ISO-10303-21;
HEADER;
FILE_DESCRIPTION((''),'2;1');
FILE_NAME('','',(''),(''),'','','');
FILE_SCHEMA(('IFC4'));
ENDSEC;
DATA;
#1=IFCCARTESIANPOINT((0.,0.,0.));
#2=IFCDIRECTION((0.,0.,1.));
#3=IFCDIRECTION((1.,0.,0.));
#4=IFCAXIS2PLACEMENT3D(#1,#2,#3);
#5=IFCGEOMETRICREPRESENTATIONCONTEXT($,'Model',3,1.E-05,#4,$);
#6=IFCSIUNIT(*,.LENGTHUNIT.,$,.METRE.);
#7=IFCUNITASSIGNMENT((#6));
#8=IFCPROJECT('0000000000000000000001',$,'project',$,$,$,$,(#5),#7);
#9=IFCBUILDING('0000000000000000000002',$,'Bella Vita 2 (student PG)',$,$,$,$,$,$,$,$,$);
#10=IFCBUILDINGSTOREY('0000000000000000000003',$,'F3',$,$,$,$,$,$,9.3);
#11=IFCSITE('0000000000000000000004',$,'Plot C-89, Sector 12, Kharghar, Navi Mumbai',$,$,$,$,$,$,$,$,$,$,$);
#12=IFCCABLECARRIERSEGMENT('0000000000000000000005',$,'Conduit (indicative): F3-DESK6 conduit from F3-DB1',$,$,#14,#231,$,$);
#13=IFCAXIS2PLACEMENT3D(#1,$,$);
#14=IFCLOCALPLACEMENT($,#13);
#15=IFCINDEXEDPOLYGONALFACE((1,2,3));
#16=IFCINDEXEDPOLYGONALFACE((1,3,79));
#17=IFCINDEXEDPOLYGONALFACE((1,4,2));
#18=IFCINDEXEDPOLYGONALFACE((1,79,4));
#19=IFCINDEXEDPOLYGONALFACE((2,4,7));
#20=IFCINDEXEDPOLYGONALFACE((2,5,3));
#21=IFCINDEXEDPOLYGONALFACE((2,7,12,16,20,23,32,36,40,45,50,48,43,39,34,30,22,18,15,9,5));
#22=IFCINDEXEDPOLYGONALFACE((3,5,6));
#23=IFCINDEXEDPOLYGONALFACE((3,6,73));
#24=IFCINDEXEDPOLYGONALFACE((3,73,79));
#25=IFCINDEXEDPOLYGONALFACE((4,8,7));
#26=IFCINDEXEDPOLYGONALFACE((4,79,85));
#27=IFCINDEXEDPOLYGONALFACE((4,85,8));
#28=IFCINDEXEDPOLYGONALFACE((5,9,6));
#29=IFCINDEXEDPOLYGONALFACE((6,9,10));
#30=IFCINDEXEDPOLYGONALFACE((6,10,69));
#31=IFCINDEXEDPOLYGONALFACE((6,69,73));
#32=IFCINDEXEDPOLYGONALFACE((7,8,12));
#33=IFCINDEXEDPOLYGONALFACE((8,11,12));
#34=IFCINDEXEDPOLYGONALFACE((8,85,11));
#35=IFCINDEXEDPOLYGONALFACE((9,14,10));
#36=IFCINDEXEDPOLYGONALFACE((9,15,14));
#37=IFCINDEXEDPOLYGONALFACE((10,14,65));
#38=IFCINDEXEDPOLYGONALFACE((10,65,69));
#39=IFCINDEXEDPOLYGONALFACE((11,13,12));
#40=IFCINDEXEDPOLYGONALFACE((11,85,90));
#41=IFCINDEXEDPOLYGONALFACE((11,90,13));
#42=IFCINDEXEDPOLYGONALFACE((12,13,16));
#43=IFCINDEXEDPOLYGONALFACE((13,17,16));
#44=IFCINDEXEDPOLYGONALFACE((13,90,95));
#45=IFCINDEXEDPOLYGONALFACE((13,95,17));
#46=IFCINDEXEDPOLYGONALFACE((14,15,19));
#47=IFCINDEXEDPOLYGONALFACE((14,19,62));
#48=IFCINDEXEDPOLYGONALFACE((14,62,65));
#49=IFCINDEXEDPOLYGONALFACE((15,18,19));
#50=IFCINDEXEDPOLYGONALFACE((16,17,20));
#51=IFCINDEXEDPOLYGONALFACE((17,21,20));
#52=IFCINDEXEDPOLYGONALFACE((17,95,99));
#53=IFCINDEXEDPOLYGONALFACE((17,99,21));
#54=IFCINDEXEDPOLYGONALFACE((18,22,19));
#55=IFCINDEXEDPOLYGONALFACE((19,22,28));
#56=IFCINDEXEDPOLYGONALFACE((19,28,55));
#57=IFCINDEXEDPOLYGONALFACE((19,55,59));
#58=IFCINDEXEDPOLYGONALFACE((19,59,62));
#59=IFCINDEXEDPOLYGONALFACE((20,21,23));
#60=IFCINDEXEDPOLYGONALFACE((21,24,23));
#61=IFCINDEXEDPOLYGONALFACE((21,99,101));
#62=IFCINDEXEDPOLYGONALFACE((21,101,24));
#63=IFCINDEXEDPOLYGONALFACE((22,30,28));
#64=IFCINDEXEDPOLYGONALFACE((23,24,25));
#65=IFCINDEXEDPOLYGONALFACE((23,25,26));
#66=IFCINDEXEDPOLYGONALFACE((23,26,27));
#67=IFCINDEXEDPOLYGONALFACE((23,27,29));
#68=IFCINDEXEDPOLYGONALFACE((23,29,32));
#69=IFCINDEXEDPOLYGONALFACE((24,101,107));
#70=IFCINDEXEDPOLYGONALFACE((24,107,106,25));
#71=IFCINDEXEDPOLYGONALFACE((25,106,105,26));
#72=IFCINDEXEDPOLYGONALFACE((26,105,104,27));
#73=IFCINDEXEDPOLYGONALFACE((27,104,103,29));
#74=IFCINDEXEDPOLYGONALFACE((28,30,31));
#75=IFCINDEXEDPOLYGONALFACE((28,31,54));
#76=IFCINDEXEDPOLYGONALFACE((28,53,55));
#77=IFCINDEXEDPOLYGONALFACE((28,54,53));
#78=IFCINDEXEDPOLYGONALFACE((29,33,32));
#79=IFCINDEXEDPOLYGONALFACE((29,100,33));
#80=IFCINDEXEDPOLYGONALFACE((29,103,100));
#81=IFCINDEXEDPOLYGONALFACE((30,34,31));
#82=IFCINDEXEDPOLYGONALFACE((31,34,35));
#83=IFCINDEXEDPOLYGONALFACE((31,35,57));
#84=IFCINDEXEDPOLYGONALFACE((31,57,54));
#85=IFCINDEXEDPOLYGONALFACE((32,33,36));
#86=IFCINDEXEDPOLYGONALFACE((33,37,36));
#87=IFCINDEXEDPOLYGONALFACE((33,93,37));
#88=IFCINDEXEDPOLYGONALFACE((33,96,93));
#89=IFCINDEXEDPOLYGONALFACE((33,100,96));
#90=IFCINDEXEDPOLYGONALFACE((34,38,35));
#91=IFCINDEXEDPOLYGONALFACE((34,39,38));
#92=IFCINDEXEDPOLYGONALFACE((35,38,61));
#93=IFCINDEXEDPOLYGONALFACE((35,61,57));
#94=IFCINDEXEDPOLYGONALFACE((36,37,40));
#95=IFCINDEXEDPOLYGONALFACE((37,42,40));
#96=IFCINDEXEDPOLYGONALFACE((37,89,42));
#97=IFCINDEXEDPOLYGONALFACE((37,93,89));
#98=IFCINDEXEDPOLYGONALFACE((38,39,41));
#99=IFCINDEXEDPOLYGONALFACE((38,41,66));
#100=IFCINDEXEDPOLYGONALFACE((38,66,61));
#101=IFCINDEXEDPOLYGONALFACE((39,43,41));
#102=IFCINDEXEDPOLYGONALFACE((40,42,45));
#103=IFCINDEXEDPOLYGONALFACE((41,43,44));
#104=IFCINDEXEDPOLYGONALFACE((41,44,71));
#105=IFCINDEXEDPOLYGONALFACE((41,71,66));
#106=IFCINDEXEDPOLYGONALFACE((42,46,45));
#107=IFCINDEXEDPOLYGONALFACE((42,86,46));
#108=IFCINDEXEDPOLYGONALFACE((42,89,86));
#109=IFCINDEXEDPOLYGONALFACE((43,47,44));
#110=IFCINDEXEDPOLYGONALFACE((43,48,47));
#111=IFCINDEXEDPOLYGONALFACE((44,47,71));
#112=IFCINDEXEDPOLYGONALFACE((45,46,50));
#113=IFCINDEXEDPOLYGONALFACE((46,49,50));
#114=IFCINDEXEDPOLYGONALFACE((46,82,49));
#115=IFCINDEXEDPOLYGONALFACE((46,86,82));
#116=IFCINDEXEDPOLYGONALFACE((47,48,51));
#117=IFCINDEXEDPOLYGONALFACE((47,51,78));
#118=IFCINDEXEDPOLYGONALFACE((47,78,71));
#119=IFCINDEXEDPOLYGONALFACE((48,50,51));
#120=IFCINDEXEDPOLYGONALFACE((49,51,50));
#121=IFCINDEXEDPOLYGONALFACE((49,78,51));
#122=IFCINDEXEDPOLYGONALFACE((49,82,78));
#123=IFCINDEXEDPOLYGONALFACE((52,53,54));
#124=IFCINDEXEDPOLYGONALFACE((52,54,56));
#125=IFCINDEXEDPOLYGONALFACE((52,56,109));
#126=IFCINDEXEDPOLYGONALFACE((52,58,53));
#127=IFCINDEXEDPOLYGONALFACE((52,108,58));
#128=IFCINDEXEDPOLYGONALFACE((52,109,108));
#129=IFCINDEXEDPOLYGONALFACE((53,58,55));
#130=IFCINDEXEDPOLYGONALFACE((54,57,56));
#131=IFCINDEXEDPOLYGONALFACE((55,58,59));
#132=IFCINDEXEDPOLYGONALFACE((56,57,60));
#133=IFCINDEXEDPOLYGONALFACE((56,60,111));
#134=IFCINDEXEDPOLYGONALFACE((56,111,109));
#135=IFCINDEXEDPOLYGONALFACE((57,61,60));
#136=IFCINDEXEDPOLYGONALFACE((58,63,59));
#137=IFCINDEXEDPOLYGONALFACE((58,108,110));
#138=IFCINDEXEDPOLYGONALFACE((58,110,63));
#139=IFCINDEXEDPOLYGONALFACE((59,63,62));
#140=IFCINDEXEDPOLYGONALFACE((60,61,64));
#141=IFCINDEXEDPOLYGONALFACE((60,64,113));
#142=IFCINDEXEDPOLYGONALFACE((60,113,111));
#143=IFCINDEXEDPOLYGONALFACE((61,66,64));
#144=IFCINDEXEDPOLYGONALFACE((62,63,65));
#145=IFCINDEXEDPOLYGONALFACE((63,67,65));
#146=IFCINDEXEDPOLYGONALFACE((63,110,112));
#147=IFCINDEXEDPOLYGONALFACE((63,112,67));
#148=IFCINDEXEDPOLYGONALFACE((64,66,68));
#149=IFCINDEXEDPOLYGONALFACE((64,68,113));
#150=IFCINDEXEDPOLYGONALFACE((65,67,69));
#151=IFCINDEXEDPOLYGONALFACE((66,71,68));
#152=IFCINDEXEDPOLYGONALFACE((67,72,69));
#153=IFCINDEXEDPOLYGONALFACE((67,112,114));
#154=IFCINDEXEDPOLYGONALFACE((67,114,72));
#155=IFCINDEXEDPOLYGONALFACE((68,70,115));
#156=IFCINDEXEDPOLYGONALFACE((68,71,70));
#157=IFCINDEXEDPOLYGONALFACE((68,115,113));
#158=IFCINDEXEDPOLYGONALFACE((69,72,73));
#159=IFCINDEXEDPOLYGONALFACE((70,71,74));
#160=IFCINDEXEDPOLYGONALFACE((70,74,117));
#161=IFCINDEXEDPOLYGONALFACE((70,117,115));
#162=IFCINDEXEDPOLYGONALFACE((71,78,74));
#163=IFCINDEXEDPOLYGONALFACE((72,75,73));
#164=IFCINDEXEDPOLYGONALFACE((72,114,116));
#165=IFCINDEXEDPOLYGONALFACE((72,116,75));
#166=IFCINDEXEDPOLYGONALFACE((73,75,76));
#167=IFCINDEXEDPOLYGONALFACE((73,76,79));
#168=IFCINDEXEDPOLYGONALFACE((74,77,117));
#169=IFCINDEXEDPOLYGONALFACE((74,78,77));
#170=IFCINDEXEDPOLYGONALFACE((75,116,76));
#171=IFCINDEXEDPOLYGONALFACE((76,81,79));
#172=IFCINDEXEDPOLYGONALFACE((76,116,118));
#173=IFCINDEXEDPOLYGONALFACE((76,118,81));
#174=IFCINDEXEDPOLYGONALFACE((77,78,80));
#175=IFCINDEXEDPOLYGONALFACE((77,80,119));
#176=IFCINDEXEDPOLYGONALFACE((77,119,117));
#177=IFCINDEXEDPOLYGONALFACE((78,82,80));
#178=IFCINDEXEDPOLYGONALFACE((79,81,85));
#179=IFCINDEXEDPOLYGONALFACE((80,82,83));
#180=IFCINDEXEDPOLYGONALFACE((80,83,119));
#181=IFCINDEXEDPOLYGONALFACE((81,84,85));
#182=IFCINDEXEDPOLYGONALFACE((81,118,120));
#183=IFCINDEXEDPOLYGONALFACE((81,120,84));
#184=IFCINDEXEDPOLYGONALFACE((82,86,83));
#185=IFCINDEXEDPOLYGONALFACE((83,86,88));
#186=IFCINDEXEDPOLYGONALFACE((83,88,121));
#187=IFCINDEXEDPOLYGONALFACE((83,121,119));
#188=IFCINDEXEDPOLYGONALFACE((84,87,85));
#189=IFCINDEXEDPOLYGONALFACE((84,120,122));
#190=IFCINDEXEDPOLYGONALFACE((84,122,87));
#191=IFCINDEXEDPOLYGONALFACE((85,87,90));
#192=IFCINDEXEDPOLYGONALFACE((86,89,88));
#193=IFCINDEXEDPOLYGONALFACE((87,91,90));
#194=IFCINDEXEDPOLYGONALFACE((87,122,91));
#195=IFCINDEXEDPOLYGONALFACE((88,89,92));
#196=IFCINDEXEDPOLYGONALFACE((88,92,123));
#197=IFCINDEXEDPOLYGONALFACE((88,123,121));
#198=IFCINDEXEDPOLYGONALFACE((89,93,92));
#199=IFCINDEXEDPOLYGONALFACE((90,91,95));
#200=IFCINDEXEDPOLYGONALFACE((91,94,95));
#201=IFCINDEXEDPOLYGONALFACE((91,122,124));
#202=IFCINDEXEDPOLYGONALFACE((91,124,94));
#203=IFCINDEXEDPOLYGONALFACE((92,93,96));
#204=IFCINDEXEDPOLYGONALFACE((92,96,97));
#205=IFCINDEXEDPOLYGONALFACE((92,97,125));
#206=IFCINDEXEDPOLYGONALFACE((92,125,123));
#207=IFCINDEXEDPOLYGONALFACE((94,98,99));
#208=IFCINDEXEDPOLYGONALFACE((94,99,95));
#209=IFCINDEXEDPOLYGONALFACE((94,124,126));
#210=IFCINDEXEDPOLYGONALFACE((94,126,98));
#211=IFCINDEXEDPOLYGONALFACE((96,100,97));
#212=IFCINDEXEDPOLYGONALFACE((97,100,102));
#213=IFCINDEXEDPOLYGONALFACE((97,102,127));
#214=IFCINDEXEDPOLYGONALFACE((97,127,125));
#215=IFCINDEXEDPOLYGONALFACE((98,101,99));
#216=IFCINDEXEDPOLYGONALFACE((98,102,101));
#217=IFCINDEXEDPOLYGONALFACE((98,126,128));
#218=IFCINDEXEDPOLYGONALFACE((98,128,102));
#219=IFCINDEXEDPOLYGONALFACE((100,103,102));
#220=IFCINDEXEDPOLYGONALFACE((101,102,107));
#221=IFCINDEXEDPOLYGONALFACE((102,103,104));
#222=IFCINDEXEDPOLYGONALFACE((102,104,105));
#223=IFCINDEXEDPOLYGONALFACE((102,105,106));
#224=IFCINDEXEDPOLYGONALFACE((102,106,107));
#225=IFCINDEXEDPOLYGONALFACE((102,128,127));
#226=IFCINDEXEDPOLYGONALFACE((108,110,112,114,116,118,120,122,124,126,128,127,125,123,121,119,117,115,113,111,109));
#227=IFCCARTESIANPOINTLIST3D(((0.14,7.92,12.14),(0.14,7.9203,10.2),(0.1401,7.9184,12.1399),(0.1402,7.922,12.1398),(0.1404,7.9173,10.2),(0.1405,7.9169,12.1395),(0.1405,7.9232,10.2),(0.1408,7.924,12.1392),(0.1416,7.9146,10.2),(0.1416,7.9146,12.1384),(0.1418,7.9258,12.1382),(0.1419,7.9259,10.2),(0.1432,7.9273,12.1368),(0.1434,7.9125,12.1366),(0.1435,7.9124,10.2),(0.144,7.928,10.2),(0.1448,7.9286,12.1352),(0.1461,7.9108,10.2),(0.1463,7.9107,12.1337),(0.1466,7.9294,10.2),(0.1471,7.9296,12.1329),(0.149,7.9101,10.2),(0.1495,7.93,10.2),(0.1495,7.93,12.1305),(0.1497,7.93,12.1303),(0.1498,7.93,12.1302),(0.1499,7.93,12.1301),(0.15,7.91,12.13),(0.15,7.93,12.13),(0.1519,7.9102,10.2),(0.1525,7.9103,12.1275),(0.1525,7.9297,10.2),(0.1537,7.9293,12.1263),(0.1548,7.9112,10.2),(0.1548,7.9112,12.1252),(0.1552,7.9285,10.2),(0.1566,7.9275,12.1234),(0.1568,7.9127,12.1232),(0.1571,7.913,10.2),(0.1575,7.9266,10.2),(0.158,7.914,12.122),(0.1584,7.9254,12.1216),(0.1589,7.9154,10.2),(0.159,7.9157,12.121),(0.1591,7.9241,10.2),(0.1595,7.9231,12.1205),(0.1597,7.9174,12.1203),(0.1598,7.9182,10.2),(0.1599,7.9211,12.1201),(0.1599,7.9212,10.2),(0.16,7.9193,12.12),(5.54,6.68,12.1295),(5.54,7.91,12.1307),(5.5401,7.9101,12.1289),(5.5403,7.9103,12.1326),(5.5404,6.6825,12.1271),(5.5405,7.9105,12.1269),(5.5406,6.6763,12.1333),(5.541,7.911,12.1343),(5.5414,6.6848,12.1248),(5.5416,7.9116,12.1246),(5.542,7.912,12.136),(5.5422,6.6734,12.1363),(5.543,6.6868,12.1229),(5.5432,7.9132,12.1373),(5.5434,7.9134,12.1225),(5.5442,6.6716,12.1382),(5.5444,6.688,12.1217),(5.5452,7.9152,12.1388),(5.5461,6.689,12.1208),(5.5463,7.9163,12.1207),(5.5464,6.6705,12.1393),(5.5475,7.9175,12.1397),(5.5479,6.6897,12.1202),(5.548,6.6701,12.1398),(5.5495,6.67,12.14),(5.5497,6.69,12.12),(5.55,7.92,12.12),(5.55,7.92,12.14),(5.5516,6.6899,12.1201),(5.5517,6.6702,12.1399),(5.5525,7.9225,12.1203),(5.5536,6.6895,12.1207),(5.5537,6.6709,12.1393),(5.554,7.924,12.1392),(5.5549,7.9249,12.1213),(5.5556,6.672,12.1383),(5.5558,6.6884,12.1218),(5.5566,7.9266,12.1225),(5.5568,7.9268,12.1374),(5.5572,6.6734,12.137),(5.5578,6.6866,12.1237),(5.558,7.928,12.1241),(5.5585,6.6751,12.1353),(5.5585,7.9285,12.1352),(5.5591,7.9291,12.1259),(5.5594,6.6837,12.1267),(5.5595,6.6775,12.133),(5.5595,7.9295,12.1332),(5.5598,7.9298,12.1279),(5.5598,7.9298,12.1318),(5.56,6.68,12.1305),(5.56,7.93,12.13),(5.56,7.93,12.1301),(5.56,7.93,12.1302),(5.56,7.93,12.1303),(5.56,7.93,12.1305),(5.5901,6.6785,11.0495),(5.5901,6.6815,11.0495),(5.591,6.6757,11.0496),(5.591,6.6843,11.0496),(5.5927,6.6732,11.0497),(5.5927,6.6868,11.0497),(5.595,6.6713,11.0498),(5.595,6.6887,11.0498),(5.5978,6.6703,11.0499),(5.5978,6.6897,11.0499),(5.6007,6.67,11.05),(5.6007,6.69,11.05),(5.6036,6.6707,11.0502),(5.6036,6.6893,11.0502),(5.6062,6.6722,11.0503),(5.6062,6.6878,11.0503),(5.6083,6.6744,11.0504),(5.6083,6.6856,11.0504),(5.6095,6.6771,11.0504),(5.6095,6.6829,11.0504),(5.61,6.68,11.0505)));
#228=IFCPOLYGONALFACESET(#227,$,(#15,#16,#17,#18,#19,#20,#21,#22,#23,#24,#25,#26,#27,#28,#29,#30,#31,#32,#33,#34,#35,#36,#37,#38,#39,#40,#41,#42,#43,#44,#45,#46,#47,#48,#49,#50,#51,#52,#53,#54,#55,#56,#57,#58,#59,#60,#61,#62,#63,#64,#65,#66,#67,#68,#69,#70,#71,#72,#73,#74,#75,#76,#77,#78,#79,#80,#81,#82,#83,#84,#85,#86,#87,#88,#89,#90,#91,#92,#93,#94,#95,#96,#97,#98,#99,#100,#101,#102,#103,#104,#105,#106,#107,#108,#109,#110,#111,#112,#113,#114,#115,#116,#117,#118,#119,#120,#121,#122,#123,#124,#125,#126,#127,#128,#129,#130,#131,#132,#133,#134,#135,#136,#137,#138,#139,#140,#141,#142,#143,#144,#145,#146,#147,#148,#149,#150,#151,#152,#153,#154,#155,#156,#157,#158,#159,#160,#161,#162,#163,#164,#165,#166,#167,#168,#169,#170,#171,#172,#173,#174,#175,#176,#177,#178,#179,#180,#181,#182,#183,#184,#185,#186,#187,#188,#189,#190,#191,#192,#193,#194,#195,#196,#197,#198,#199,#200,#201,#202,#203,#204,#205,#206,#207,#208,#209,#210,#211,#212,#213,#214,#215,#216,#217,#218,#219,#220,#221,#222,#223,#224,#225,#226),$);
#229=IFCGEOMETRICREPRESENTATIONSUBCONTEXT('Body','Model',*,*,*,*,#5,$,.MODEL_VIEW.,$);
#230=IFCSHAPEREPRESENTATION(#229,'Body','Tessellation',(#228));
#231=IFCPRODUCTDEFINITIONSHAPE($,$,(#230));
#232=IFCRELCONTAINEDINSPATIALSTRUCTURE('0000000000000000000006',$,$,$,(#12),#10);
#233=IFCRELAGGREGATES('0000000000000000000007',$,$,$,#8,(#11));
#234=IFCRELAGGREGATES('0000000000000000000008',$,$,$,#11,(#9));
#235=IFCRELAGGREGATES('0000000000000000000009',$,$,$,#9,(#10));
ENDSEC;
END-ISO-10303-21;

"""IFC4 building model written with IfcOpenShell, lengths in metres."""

from ifc_helpers import new_model, entity, si_unit, origin, origin_with_axes, place, context, subcontext, project, spatial, element, save


model = new_model("IFC4")

# Units and contexts
model_context = context("Model", 3, precision=1e-05, world=origin_with_axes())
body_context = subcontext(model_context, "Body", "Model", "MODEL_VIEW")
ifc_project = project(units=[si_unit("LENGTHUNIT", "METRE")], contexts=[model_context])

# Site, building, storey
site = spatial("IfcSite", under=ifc_project, Name="Plot C-89, Sector 12, Kharghar, Navi Mumbai")
building = spatial("IfcBuilding", under=site, Name="Bella Vita 2 (student PG)")
storey = spatial("IfcBuildingStorey", under=building, Name="F3", Elevation=9.3)

# Cable carrier segment
cable_carrier_segment_1_placement = place(None, origin())
element("IfcCableCarrierSegment", 1, at=cable_carrier_segment_1_placement, inside=storey, Name="Conduit (indicative): F3-DESK6 conduit from F3-DB1", context=body_context, shape_type="AdvancedSweptSolid", body=[
    entity("IfcSweptDiskSolid", entity("IfcPolyline", [entity("IfcCartesianPoint", [5.6, 6.68, 11.05]), entity("IfcCartesianPoint", [5.55, 6.68, 12.13]), entity("IfcCartesianPoint", [5.55, 7.92, 12.13]), entity("IfcCartesianPoint", [0.15, 7.92, 12.13]), entity("IfcCartesianPoint", [0.15, 7.92, 10.2])]), 0.01),
])

save(model, "model.ifc")
